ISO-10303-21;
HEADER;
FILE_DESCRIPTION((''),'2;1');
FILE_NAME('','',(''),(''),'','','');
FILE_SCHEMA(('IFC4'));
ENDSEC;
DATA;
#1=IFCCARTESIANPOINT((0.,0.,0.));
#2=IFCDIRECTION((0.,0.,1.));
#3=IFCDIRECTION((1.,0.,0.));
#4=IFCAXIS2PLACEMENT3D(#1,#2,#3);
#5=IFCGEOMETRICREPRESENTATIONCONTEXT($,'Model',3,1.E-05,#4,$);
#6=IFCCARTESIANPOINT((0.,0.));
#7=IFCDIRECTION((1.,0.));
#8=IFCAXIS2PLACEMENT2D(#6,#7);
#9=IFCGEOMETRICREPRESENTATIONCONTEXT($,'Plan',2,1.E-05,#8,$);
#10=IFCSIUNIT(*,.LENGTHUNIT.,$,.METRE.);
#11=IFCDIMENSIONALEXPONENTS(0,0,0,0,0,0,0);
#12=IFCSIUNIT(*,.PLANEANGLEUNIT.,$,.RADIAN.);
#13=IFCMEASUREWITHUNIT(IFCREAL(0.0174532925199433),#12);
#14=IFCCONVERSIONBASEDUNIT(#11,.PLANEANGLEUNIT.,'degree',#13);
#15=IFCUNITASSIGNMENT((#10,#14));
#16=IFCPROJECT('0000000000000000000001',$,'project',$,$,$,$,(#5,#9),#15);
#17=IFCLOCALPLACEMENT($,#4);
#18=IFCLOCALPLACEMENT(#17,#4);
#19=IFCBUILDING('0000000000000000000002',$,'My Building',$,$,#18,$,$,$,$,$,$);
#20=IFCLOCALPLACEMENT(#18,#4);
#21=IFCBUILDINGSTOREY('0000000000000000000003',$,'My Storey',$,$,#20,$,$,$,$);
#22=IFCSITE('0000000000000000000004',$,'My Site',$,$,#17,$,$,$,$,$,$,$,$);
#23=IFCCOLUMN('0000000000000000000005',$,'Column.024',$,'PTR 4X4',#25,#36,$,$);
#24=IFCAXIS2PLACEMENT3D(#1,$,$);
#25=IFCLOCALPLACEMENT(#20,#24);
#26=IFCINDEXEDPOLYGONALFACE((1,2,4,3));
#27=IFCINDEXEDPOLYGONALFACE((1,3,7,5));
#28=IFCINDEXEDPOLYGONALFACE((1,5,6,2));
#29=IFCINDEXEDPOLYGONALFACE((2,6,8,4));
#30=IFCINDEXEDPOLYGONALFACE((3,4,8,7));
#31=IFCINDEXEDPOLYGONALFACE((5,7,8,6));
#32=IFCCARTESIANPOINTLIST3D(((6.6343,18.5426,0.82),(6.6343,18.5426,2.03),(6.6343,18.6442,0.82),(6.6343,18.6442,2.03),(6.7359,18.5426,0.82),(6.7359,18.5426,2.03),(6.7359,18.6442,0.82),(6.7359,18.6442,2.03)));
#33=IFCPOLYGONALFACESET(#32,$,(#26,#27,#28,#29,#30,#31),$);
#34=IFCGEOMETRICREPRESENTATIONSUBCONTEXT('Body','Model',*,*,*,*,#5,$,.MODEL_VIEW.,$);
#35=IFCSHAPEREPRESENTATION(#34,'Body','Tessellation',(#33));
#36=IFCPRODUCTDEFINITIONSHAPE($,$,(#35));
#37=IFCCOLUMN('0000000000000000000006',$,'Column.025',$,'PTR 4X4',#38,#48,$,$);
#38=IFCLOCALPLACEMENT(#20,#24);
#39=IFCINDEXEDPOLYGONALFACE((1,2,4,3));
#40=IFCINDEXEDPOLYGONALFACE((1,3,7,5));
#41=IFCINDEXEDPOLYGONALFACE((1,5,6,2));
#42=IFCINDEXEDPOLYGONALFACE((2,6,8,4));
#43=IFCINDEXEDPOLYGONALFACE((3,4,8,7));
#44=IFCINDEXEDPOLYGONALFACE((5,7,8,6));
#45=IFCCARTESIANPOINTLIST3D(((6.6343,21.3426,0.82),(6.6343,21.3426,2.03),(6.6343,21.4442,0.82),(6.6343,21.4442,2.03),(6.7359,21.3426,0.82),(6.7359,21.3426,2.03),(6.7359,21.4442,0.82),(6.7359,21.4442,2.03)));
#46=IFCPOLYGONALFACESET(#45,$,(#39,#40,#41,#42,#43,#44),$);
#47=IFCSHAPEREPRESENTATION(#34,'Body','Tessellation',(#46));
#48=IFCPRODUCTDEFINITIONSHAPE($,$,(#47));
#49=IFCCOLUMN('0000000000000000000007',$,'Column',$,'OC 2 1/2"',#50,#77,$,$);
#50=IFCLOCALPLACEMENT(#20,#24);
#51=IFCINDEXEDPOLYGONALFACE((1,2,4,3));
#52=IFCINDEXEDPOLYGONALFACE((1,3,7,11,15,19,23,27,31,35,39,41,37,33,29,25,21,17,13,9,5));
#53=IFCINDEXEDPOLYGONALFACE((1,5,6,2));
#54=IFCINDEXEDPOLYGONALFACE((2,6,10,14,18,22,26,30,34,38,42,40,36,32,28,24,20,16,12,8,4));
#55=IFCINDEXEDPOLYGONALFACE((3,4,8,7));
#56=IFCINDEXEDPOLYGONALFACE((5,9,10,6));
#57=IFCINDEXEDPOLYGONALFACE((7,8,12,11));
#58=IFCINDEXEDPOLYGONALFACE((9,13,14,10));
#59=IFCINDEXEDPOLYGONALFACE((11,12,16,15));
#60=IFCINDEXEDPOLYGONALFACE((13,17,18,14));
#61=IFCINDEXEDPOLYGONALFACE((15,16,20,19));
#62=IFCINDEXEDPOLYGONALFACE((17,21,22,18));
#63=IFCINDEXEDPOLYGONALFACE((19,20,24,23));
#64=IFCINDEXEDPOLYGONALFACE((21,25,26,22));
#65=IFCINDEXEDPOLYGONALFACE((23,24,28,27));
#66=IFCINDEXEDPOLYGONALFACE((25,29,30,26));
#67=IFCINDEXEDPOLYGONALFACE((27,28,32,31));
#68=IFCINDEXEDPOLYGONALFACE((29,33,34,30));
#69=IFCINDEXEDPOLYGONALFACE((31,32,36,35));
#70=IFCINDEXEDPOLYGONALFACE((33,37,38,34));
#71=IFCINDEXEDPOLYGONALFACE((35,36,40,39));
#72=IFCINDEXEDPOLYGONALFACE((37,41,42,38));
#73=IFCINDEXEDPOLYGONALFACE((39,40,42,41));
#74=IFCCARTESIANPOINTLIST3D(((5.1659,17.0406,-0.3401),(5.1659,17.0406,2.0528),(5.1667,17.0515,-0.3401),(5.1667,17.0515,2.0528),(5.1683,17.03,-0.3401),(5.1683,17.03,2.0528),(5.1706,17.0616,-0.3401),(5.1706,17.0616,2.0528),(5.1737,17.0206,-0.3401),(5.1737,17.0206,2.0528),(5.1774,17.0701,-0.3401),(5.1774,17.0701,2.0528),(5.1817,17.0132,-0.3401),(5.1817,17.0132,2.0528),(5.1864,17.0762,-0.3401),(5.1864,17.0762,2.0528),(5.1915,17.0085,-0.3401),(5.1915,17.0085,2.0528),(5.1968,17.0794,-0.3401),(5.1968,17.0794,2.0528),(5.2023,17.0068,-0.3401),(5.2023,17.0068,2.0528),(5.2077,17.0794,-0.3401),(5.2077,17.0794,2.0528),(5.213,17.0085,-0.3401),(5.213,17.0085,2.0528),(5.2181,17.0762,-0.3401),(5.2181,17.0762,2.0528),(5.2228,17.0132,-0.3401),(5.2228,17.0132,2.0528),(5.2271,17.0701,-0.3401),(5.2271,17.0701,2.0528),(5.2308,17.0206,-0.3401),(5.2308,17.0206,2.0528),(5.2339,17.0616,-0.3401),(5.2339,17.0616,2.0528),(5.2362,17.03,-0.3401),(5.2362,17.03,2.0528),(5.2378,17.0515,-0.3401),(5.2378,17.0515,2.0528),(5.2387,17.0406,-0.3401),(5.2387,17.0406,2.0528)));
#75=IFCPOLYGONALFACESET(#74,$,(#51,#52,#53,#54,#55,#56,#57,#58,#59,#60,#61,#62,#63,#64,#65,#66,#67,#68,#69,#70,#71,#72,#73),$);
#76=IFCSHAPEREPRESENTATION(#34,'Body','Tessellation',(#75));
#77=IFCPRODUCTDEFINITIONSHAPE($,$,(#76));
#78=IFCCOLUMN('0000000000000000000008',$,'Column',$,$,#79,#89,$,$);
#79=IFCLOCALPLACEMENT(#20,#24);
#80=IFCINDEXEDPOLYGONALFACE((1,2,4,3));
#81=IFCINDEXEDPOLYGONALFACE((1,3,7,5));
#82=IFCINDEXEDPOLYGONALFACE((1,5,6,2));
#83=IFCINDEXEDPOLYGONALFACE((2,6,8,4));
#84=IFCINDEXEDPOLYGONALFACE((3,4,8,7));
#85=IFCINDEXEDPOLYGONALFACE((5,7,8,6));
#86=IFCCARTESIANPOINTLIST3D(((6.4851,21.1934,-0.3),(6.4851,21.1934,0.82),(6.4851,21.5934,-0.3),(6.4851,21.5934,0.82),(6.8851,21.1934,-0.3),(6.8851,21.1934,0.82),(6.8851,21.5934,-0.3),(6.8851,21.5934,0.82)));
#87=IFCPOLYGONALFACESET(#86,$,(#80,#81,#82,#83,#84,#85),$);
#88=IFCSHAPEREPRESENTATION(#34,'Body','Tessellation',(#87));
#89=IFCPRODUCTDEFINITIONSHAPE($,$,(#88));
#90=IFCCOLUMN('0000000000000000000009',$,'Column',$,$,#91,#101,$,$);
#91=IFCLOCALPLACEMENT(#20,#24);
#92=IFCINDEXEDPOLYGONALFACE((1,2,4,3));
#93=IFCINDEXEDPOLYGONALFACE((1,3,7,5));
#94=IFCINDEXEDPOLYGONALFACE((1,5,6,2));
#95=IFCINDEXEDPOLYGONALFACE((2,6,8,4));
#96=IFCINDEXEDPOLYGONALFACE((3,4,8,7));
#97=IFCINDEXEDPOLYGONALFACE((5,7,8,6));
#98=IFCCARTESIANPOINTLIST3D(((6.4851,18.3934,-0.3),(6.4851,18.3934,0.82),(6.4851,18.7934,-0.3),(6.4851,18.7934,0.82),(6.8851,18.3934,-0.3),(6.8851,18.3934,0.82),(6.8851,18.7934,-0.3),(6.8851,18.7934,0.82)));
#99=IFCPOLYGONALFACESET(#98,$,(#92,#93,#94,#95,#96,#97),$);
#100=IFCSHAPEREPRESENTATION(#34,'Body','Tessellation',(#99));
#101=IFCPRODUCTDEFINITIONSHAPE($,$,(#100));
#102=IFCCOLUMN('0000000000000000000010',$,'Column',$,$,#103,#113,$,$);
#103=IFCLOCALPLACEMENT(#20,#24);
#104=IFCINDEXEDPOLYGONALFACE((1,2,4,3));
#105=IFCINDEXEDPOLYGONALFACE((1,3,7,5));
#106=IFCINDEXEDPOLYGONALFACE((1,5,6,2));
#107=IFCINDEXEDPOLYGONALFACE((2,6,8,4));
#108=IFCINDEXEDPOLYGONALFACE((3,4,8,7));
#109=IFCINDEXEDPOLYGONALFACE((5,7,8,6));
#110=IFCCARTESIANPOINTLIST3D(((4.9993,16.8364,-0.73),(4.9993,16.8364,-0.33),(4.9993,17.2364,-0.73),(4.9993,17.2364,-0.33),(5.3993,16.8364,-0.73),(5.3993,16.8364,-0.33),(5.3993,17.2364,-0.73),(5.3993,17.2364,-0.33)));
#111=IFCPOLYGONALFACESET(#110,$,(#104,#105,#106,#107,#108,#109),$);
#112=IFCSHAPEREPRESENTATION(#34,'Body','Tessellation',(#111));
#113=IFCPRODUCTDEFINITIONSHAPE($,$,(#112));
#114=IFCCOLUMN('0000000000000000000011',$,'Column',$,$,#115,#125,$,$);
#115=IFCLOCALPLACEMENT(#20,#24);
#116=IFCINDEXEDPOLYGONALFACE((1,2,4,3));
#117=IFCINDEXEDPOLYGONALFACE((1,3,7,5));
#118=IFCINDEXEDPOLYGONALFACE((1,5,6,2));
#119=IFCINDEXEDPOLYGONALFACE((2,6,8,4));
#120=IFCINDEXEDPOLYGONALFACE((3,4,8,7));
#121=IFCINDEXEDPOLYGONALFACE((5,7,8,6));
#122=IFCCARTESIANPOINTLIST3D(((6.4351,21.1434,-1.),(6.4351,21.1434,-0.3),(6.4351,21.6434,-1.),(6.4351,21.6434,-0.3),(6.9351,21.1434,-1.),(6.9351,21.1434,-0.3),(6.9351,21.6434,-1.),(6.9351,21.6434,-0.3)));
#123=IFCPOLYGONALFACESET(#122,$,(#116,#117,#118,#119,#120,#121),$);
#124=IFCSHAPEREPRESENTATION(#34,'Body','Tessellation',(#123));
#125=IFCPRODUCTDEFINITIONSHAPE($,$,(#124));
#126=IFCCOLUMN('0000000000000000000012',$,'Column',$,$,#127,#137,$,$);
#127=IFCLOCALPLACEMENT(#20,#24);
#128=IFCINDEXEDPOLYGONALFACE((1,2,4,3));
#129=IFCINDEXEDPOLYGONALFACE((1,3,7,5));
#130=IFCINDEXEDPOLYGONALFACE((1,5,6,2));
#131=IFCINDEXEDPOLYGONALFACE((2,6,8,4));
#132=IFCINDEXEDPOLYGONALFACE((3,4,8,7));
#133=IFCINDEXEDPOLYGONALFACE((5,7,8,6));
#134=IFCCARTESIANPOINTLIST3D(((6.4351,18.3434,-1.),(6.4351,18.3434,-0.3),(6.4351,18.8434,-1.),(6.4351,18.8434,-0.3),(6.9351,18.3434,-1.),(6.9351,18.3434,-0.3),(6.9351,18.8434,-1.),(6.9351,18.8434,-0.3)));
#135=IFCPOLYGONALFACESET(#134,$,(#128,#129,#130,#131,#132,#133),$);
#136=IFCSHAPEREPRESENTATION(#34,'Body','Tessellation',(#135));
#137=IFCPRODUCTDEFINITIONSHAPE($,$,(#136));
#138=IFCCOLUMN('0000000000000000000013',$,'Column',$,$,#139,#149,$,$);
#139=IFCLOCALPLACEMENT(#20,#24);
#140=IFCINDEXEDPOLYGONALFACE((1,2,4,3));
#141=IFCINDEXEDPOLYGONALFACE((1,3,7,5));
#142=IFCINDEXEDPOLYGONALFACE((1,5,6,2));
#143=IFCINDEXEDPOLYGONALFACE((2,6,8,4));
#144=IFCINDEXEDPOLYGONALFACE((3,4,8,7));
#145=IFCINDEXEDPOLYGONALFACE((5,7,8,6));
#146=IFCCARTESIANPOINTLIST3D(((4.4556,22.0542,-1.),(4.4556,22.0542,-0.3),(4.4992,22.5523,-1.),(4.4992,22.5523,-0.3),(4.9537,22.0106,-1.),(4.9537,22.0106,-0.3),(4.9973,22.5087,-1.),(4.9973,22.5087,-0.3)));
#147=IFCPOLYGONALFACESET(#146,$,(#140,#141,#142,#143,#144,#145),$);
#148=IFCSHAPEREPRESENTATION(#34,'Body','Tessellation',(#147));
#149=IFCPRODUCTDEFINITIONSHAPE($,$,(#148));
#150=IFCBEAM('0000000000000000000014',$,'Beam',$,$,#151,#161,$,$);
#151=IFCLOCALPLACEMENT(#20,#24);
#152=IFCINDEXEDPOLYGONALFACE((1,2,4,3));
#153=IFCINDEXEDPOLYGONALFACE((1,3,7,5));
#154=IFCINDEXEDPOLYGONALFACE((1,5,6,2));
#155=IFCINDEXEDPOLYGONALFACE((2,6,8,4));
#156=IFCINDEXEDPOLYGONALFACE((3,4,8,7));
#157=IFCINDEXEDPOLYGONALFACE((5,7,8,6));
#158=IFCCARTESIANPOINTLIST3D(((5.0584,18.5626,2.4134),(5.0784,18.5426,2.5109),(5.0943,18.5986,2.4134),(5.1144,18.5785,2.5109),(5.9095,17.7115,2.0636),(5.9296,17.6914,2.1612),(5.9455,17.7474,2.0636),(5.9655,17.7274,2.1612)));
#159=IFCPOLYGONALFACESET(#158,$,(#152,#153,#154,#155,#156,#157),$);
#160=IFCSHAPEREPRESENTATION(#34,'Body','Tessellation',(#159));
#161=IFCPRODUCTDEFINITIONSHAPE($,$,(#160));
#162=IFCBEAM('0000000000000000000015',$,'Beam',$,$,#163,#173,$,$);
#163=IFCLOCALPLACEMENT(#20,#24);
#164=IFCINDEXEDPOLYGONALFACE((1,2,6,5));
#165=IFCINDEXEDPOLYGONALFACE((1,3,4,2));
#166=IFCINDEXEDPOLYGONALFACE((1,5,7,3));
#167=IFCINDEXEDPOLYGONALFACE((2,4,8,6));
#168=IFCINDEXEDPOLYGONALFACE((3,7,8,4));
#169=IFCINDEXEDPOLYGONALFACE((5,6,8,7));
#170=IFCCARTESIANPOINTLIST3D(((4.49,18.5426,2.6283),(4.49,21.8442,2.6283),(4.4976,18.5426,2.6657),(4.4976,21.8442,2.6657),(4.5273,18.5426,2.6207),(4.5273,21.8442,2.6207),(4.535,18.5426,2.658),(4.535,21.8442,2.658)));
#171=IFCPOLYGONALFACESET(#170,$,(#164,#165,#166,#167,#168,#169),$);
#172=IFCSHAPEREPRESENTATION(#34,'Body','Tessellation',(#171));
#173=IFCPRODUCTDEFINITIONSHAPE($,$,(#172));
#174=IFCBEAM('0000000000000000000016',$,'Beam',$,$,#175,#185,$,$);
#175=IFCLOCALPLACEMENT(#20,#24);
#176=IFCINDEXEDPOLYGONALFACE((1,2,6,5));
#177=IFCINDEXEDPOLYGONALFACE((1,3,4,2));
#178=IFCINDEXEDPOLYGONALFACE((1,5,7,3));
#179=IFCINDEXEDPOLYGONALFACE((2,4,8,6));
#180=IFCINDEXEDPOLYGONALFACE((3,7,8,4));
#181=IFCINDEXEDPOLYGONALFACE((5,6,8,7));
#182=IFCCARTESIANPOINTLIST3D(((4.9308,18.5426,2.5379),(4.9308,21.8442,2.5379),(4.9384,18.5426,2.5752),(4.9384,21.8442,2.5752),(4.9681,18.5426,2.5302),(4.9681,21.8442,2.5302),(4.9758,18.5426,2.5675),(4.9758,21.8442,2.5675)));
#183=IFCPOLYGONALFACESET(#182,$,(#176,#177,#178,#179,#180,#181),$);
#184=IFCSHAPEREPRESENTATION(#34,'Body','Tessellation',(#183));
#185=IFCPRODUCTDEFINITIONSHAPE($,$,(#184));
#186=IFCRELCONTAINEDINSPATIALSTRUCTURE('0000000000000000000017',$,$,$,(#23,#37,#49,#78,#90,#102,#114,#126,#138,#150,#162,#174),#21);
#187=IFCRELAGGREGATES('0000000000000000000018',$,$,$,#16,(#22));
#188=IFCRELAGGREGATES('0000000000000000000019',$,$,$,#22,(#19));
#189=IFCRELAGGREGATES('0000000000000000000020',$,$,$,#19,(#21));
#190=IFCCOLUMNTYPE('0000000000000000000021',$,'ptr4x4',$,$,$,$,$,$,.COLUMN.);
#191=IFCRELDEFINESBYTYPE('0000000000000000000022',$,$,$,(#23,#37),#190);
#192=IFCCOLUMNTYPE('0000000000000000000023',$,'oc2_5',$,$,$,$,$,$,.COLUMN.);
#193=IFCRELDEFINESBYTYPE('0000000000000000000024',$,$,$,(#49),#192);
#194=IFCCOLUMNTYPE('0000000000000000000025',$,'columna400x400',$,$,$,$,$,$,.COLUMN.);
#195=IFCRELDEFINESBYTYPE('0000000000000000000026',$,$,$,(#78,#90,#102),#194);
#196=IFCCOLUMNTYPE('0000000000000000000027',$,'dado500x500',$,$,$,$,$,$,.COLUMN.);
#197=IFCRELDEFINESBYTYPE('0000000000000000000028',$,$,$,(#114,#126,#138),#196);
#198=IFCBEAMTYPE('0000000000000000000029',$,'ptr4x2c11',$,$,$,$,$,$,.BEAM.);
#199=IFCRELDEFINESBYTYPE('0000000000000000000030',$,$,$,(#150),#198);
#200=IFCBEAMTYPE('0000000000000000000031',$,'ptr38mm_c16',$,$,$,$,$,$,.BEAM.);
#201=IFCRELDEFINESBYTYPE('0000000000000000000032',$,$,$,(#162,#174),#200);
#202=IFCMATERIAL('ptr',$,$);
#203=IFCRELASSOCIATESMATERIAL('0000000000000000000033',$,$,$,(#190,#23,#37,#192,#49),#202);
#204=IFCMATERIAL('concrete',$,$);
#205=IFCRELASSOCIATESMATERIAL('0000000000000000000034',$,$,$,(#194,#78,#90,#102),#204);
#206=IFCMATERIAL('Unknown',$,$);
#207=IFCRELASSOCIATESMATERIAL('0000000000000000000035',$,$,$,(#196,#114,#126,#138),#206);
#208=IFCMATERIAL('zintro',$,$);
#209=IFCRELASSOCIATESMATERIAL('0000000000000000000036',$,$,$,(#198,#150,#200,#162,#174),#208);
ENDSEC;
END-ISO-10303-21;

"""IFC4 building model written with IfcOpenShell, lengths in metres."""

from ifc_helpers import new_model, entity, si_unit, converted_unit, frame, origin_with_axes, origin_2d_with_axis, place, context, subcontext, project, spatial, rectangle, circle, extrude, material, material_profile, profile_set, profile_usage, type_object, element, save


model = new_model("IFC4")

# Units and contexts
model_context = context("Model", 3, precision=1e-05, world=origin_with_axes())
plan_context = context("Plan", 2, precision=1e-05, world=origin_2d_with_axis())
body_context = subcontext(model_context, "Body", "Model", "MODEL_VIEW")
ifc_project = project(units=[si_unit("LENGTHUNIT", "METRE"), converted_unit("PLANEANGLEUNIT", "degree", entity("IfcReal", 0.0174532925199433), si_unit("PLANEANGLEUNIT", "RADIAN"), dimensions=[0, 0, 0, 0, 0, 0, 0])], contexts=[model_context, plan_context])

# Site, building, storey
site_placement = place(None, origin_with_axes())
site = spatial("IfcSite", under=ifc_project, at=site_placement, Name="My Site")
building_placement = place(site_placement, origin_with_axes())
building = spatial("IfcBuilding", under=site, at=building_placement, Name="My Building")
storey_placement = place(building_placement, origin_with_axes())
storey = spatial("IfcBuildingStorey", under=building, at=storey_placement, Name="My Storey")

# Columns
ifc_material_1 = material(Name="ptr")
ifc_material_profile_1 = material_profile(ifc_material_1, rectangle(XDim=0.1016, YDim=0.1016))
ifc_profile_set_1 = profile_set([ifc_material_profile_1])
ifc_profile_usage_1 = profile_usage(ifc_profile_set_1, cardinal=5)
column_type_1 = type_object("IfcColumnType", Name="ptr4x4", PredefinedType="COLUMN", material=ifc_profile_set_1)
column_1_placement = place(storey_placement, frame((6.6851, 18.5934, 0.82), z_axis=(0.0, 0.0, 1.0), x_axis=(0.0, 1.0, 0.0)))
element("IfcColumn", 1, at=column_1_placement, inside=storey, type_object=column_type_1, material=ifc_profile_usage_1, Name="Column.024", ObjectType="PTR 4X4", context=body_context, shape_type="SweptSolid", body=[
    extrude(rectangle(XDim=0.1016, YDim=0.1016), origin_with_axes(), (0.0, 0.0, 1.0), 1.21),
])
ifc_profile_usage_2 = profile_usage(ifc_profile_set_1, cardinal=5)
column_2_placement = place(storey_placement, frame((6.6851, 21.3934, 0.82), z_axis=(0.0, 0.0, 1.0), x_axis=(0.0, 1.0, 0.0)))
element("IfcColumn", 2, at=column_2_placement, inside=storey, type_object=column_type_1, material=ifc_profile_usage_2, Name="Column.025", ObjectType="PTR 4X4", context=body_context, shape_type="SweptSolid", body=[
    extrude(rectangle(XDim=0.1016, YDim=0.1016), origin_with_axes(), (0.0, 0.0, 1.0), 1.21),
])
ifc_material_profile_2 = material_profile(ifc_material_1, circle(Radius=0.0365))
ifc_profile_set_2 = profile_set([ifc_material_profile_2])
ifc_profile_usage_3 = profile_usage(ifc_profile_set_2)
column_type_2 = type_object("IfcColumnType", Name="oc2_5", PredefinedType="COLUMN", material=ifc_profile_set_2)
column_3_placement = place(storey_placement, frame((5.2023, 17.0433, -0.3401), z_axis=(0.0, 0.0, 1.0), x_axis=(0.0, -1.0, 0.0)))
element("IfcColumn", 3, at=column_3_placement, inside=storey, type_object=column_type_2, material=ifc_profile_usage_3, Name="Column", ObjectType="OC 2 1/2\"", context=body_context, shape_type="SweptSolid", body=[
    extrude(circle(Radius=0.0365), origin_with_axes(), (0.0, 0.0, 1.0), 2.3929),
])
ifc_material_2 = material(Name="concrete")
ifc_material_profile_3 = material_profile(ifc_material_2, rectangle(XDim=0.4, YDim=0.4))
ifc_profile_set_3 = profile_set([ifc_material_profile_3], Name="concrete")
ifc_profile_usage_4 = profile_usage(ifc_profile_set_3)
column_type_3 = type_object("IfcColumnType", Name="columna400x400", PredefinedType="COLUMN", material=ifc_profile_set_3)
column_4_placement = place(storey_placement, frame((6.6851, 21.3934, -0.3), z_axis=(0.0, 0.0, 1.0), x_axis=(1.0, 0.0, 0.0)))
element("IfcColumn", 4, at=column_4_placement, inside=storey, type_object=column_type_3, material=ifc_profile_usage_4, Name="Column", context=body_context, shape_type="SweptSolid", body=[
    extrude(rectangle(XDim=0.4, YDim=0.4), origin_with_axes(), (0.0, 0.0, 1.0), 1.12),
])
ifc_profile_usage_5 = profile_usage(ifc_profile_set_3)
column_5_placement = place(storey_placement, frame((6.6851, 18.5934, -0.3), z_axis=(0.0, 0.0, 1.0), x_axis=(1.0, 0.0, 0.0)))
element("IfcColumn", 5, at=column_5_placement, inside=storey, type_object=column_type_3, material=ifc_profile_usage_5, Name="Column", context=body_context, shape_type="SweptSolid", body=[
    extrude(rectangle(XDim=0.4, YDim=0.4), origin_with_axes(), (0.0, 0.0, 1.0), 1.12),
])
ifc_profile_usage_6 = profile_usage(ifc_profile_set_3, cardinal=5)
column_6_placement = place(storey_placement, frame((5.1993, 17.0364, -0.73), z_axis=(0.0, 0.0, 1.0), x_axis=(1.0, 0.0, 0.0)))
element("IfcColumn", 6, at=column_6_placement, inside=storey, type_object=column_type_3, material=ifc_profile_usage_6, Name="Column", context=body_context, shape_type="SweptSolid", body=[
    extrude(rectangle(XDim=0.4, YDim=0.4), origin_with_axes(), (0.0, 0.0, 1.0), 0.4),
])
ifc_material_3 = material(Name="Unknown")
ifc_material_profile_4 = material_profile(ifc_material_3, rectangle(XDim=0.5, YDim=0.5))
ifc_profile_set_4 = profile_set([ifc_material_profile_4], Name="concrete")
ifc_profile_usage_7 = profile_usage(ifc_profile_set_4)
column_type_4 = type_object("IfcColumnType", Name="dado500x500", PredefinedType="COLUMN", material=ifc_profile_set_4)
column_7_placement = place(storey_placement, frame((6.6851, 21.3934, -1.0), z_axis=(0.0, 0.0, 1.0), x_axis=(1.0, 0.0, 0.0)))
element("IfcColumn", 7, at=column_7_placement, inside=storey, type_object=column_type_4, material=ifc_profile_usage_7, Name="Column", context=body_context, shape_type="SweptSolid", body=[
    extrude(rectangle(XDim=0.5, YDim=0.5), origin_with_axes(), (0.0, 0.0, 1.0), 0.7),
])
ifc_profile_usage_8 = profile_usage(ifc_profile_set_4)
column_8_placement = place(storey_placement, frame((6.6851, 18.5934, -1.0), z_axis=(0.0, 0.0, 1.0), x_axis=(1.0, 0.0, 0.0)))
element("IfcColumn", 8, at=column_8_placement, inside=storey, type_object=column_type_4, material=ifc_profile_usage_8, Name="Column", context=body_context, shape_type="SweptSolid", body=[
    extrude(rectangle(XDim=0.5, YDim=0.5), origin_with_axes(), (0.0, 0.0, 1.0), 0.7),
])
ifc_profile_usage_9 = profile_usage(ifc_profile_set_4)
column_9_placement = place(storey_placement, frame((4.7264, 22.2815, -1.0), z_axis=(0.0, 0.0, 1.0), x_axis=(0.996195, -0.087156, 0.0)))
element("IfcColumn", 9, at=column_9_placement, inside=storey, type_object=column_type_4, material=ifc_profile_usage_9, Name="Column", context=body_context, shape_type="SweptSolid", body=[
    extrude(rectangle(XDim=0.5, YDim=0.5), origin_with_axes(), (0.0, 0.0, 1.0), 0.7),
])

# Beams
ifc_material_4 = material(Name="zintro")
ifc_material_profile_5 = material_profile(ifc_material_4, rectangle(XDim=0.0508, YDim=0.1016))
ifc_profile_set_5 = profile_set([ifc_material_profile_5])
ifc_profile_usage_10 = profile_usage(ifc_profile_set_5)
beam_type_1 = type_object("IfcBeamType", Name="ptr4x2c11", PredefinedType="BEAM", material=ifc_profile_set_5)
beam_1_placement = place(storey_placement, frame((5.0864, 18.5706, 2.4621), z_axis=(0.67903, -0.67903, -0.278991), x_axis=(0.707107, 0.707107, 0.0)))
element("IfcBeam", 10, at=beam_1_placement, inside=storey, type_object=beam_type_1, material=ifc_profile_usage_10, Name="Beam", context=body_context, shape_type="SweptSolid", body=[
    extrude(rectangle(XDim=0.0508, YDim=0.1016), origin_with_axes(), (0.0, 0.0, 1.0), 1.2535),
])
ifc_material_profile_6 = material_profile(ifc_material_4, rectangle(XDim=0.0381, YDim=0.0381))
ifc_profile_set_6 = profile_set([ifc_material_profile_6])
ifc_profile_usage_11 = profile_usage(ifc_profile_set_6)
beam_type_2 = type_object("IfcBeamType", Name="ptr38mm_c16", PredefinedType="BEAM", material=ifc_profile_set_6)
beam_2_placement = place(storey_placement, frame((4.5125, 21.8442, 2.6432), z_axis=(0.0, -1.0, 0.0), x_axis=(0.979575, 0.0, -0.201078)))
element("IfcBeam", 11, at=beam_2_placement, inside=storey, type_object=beam_type_2, material=ifc_profile_usage_11, Name="Beam", context=body_context, shape_type="SweptSolid", body=[
    extrude(rectangle(XDim=0.0381, YDim=0.0381), origin_with_axes(), (0.0, 0.0, 1.0), 3.3016),
])
ifc_profile_usage_12 = profile_usage(ifc_profile_set_6)
beam_3_placement = place(storey_placement, frame((4.9533, 21.8442, 2.5527), z_axis=(0.0, -1.0, 0.0), x_axis=(0.979575, 0.0, -0.201078)))
element("IfcBeam", 12, at=beam_3_placement, inside=storey, type_object=beam_type_2, material=ifc_profile_usage_12, Name="Beam", context=body_context, shape_type="SweptSolid", body=[
    extrude(rectangle(XDim=0.0381, YDim=0.0381), origin_with_axes(), (0.0, 0.0, 1.0), 3.3016),
])

save(model, "model.ifc")
